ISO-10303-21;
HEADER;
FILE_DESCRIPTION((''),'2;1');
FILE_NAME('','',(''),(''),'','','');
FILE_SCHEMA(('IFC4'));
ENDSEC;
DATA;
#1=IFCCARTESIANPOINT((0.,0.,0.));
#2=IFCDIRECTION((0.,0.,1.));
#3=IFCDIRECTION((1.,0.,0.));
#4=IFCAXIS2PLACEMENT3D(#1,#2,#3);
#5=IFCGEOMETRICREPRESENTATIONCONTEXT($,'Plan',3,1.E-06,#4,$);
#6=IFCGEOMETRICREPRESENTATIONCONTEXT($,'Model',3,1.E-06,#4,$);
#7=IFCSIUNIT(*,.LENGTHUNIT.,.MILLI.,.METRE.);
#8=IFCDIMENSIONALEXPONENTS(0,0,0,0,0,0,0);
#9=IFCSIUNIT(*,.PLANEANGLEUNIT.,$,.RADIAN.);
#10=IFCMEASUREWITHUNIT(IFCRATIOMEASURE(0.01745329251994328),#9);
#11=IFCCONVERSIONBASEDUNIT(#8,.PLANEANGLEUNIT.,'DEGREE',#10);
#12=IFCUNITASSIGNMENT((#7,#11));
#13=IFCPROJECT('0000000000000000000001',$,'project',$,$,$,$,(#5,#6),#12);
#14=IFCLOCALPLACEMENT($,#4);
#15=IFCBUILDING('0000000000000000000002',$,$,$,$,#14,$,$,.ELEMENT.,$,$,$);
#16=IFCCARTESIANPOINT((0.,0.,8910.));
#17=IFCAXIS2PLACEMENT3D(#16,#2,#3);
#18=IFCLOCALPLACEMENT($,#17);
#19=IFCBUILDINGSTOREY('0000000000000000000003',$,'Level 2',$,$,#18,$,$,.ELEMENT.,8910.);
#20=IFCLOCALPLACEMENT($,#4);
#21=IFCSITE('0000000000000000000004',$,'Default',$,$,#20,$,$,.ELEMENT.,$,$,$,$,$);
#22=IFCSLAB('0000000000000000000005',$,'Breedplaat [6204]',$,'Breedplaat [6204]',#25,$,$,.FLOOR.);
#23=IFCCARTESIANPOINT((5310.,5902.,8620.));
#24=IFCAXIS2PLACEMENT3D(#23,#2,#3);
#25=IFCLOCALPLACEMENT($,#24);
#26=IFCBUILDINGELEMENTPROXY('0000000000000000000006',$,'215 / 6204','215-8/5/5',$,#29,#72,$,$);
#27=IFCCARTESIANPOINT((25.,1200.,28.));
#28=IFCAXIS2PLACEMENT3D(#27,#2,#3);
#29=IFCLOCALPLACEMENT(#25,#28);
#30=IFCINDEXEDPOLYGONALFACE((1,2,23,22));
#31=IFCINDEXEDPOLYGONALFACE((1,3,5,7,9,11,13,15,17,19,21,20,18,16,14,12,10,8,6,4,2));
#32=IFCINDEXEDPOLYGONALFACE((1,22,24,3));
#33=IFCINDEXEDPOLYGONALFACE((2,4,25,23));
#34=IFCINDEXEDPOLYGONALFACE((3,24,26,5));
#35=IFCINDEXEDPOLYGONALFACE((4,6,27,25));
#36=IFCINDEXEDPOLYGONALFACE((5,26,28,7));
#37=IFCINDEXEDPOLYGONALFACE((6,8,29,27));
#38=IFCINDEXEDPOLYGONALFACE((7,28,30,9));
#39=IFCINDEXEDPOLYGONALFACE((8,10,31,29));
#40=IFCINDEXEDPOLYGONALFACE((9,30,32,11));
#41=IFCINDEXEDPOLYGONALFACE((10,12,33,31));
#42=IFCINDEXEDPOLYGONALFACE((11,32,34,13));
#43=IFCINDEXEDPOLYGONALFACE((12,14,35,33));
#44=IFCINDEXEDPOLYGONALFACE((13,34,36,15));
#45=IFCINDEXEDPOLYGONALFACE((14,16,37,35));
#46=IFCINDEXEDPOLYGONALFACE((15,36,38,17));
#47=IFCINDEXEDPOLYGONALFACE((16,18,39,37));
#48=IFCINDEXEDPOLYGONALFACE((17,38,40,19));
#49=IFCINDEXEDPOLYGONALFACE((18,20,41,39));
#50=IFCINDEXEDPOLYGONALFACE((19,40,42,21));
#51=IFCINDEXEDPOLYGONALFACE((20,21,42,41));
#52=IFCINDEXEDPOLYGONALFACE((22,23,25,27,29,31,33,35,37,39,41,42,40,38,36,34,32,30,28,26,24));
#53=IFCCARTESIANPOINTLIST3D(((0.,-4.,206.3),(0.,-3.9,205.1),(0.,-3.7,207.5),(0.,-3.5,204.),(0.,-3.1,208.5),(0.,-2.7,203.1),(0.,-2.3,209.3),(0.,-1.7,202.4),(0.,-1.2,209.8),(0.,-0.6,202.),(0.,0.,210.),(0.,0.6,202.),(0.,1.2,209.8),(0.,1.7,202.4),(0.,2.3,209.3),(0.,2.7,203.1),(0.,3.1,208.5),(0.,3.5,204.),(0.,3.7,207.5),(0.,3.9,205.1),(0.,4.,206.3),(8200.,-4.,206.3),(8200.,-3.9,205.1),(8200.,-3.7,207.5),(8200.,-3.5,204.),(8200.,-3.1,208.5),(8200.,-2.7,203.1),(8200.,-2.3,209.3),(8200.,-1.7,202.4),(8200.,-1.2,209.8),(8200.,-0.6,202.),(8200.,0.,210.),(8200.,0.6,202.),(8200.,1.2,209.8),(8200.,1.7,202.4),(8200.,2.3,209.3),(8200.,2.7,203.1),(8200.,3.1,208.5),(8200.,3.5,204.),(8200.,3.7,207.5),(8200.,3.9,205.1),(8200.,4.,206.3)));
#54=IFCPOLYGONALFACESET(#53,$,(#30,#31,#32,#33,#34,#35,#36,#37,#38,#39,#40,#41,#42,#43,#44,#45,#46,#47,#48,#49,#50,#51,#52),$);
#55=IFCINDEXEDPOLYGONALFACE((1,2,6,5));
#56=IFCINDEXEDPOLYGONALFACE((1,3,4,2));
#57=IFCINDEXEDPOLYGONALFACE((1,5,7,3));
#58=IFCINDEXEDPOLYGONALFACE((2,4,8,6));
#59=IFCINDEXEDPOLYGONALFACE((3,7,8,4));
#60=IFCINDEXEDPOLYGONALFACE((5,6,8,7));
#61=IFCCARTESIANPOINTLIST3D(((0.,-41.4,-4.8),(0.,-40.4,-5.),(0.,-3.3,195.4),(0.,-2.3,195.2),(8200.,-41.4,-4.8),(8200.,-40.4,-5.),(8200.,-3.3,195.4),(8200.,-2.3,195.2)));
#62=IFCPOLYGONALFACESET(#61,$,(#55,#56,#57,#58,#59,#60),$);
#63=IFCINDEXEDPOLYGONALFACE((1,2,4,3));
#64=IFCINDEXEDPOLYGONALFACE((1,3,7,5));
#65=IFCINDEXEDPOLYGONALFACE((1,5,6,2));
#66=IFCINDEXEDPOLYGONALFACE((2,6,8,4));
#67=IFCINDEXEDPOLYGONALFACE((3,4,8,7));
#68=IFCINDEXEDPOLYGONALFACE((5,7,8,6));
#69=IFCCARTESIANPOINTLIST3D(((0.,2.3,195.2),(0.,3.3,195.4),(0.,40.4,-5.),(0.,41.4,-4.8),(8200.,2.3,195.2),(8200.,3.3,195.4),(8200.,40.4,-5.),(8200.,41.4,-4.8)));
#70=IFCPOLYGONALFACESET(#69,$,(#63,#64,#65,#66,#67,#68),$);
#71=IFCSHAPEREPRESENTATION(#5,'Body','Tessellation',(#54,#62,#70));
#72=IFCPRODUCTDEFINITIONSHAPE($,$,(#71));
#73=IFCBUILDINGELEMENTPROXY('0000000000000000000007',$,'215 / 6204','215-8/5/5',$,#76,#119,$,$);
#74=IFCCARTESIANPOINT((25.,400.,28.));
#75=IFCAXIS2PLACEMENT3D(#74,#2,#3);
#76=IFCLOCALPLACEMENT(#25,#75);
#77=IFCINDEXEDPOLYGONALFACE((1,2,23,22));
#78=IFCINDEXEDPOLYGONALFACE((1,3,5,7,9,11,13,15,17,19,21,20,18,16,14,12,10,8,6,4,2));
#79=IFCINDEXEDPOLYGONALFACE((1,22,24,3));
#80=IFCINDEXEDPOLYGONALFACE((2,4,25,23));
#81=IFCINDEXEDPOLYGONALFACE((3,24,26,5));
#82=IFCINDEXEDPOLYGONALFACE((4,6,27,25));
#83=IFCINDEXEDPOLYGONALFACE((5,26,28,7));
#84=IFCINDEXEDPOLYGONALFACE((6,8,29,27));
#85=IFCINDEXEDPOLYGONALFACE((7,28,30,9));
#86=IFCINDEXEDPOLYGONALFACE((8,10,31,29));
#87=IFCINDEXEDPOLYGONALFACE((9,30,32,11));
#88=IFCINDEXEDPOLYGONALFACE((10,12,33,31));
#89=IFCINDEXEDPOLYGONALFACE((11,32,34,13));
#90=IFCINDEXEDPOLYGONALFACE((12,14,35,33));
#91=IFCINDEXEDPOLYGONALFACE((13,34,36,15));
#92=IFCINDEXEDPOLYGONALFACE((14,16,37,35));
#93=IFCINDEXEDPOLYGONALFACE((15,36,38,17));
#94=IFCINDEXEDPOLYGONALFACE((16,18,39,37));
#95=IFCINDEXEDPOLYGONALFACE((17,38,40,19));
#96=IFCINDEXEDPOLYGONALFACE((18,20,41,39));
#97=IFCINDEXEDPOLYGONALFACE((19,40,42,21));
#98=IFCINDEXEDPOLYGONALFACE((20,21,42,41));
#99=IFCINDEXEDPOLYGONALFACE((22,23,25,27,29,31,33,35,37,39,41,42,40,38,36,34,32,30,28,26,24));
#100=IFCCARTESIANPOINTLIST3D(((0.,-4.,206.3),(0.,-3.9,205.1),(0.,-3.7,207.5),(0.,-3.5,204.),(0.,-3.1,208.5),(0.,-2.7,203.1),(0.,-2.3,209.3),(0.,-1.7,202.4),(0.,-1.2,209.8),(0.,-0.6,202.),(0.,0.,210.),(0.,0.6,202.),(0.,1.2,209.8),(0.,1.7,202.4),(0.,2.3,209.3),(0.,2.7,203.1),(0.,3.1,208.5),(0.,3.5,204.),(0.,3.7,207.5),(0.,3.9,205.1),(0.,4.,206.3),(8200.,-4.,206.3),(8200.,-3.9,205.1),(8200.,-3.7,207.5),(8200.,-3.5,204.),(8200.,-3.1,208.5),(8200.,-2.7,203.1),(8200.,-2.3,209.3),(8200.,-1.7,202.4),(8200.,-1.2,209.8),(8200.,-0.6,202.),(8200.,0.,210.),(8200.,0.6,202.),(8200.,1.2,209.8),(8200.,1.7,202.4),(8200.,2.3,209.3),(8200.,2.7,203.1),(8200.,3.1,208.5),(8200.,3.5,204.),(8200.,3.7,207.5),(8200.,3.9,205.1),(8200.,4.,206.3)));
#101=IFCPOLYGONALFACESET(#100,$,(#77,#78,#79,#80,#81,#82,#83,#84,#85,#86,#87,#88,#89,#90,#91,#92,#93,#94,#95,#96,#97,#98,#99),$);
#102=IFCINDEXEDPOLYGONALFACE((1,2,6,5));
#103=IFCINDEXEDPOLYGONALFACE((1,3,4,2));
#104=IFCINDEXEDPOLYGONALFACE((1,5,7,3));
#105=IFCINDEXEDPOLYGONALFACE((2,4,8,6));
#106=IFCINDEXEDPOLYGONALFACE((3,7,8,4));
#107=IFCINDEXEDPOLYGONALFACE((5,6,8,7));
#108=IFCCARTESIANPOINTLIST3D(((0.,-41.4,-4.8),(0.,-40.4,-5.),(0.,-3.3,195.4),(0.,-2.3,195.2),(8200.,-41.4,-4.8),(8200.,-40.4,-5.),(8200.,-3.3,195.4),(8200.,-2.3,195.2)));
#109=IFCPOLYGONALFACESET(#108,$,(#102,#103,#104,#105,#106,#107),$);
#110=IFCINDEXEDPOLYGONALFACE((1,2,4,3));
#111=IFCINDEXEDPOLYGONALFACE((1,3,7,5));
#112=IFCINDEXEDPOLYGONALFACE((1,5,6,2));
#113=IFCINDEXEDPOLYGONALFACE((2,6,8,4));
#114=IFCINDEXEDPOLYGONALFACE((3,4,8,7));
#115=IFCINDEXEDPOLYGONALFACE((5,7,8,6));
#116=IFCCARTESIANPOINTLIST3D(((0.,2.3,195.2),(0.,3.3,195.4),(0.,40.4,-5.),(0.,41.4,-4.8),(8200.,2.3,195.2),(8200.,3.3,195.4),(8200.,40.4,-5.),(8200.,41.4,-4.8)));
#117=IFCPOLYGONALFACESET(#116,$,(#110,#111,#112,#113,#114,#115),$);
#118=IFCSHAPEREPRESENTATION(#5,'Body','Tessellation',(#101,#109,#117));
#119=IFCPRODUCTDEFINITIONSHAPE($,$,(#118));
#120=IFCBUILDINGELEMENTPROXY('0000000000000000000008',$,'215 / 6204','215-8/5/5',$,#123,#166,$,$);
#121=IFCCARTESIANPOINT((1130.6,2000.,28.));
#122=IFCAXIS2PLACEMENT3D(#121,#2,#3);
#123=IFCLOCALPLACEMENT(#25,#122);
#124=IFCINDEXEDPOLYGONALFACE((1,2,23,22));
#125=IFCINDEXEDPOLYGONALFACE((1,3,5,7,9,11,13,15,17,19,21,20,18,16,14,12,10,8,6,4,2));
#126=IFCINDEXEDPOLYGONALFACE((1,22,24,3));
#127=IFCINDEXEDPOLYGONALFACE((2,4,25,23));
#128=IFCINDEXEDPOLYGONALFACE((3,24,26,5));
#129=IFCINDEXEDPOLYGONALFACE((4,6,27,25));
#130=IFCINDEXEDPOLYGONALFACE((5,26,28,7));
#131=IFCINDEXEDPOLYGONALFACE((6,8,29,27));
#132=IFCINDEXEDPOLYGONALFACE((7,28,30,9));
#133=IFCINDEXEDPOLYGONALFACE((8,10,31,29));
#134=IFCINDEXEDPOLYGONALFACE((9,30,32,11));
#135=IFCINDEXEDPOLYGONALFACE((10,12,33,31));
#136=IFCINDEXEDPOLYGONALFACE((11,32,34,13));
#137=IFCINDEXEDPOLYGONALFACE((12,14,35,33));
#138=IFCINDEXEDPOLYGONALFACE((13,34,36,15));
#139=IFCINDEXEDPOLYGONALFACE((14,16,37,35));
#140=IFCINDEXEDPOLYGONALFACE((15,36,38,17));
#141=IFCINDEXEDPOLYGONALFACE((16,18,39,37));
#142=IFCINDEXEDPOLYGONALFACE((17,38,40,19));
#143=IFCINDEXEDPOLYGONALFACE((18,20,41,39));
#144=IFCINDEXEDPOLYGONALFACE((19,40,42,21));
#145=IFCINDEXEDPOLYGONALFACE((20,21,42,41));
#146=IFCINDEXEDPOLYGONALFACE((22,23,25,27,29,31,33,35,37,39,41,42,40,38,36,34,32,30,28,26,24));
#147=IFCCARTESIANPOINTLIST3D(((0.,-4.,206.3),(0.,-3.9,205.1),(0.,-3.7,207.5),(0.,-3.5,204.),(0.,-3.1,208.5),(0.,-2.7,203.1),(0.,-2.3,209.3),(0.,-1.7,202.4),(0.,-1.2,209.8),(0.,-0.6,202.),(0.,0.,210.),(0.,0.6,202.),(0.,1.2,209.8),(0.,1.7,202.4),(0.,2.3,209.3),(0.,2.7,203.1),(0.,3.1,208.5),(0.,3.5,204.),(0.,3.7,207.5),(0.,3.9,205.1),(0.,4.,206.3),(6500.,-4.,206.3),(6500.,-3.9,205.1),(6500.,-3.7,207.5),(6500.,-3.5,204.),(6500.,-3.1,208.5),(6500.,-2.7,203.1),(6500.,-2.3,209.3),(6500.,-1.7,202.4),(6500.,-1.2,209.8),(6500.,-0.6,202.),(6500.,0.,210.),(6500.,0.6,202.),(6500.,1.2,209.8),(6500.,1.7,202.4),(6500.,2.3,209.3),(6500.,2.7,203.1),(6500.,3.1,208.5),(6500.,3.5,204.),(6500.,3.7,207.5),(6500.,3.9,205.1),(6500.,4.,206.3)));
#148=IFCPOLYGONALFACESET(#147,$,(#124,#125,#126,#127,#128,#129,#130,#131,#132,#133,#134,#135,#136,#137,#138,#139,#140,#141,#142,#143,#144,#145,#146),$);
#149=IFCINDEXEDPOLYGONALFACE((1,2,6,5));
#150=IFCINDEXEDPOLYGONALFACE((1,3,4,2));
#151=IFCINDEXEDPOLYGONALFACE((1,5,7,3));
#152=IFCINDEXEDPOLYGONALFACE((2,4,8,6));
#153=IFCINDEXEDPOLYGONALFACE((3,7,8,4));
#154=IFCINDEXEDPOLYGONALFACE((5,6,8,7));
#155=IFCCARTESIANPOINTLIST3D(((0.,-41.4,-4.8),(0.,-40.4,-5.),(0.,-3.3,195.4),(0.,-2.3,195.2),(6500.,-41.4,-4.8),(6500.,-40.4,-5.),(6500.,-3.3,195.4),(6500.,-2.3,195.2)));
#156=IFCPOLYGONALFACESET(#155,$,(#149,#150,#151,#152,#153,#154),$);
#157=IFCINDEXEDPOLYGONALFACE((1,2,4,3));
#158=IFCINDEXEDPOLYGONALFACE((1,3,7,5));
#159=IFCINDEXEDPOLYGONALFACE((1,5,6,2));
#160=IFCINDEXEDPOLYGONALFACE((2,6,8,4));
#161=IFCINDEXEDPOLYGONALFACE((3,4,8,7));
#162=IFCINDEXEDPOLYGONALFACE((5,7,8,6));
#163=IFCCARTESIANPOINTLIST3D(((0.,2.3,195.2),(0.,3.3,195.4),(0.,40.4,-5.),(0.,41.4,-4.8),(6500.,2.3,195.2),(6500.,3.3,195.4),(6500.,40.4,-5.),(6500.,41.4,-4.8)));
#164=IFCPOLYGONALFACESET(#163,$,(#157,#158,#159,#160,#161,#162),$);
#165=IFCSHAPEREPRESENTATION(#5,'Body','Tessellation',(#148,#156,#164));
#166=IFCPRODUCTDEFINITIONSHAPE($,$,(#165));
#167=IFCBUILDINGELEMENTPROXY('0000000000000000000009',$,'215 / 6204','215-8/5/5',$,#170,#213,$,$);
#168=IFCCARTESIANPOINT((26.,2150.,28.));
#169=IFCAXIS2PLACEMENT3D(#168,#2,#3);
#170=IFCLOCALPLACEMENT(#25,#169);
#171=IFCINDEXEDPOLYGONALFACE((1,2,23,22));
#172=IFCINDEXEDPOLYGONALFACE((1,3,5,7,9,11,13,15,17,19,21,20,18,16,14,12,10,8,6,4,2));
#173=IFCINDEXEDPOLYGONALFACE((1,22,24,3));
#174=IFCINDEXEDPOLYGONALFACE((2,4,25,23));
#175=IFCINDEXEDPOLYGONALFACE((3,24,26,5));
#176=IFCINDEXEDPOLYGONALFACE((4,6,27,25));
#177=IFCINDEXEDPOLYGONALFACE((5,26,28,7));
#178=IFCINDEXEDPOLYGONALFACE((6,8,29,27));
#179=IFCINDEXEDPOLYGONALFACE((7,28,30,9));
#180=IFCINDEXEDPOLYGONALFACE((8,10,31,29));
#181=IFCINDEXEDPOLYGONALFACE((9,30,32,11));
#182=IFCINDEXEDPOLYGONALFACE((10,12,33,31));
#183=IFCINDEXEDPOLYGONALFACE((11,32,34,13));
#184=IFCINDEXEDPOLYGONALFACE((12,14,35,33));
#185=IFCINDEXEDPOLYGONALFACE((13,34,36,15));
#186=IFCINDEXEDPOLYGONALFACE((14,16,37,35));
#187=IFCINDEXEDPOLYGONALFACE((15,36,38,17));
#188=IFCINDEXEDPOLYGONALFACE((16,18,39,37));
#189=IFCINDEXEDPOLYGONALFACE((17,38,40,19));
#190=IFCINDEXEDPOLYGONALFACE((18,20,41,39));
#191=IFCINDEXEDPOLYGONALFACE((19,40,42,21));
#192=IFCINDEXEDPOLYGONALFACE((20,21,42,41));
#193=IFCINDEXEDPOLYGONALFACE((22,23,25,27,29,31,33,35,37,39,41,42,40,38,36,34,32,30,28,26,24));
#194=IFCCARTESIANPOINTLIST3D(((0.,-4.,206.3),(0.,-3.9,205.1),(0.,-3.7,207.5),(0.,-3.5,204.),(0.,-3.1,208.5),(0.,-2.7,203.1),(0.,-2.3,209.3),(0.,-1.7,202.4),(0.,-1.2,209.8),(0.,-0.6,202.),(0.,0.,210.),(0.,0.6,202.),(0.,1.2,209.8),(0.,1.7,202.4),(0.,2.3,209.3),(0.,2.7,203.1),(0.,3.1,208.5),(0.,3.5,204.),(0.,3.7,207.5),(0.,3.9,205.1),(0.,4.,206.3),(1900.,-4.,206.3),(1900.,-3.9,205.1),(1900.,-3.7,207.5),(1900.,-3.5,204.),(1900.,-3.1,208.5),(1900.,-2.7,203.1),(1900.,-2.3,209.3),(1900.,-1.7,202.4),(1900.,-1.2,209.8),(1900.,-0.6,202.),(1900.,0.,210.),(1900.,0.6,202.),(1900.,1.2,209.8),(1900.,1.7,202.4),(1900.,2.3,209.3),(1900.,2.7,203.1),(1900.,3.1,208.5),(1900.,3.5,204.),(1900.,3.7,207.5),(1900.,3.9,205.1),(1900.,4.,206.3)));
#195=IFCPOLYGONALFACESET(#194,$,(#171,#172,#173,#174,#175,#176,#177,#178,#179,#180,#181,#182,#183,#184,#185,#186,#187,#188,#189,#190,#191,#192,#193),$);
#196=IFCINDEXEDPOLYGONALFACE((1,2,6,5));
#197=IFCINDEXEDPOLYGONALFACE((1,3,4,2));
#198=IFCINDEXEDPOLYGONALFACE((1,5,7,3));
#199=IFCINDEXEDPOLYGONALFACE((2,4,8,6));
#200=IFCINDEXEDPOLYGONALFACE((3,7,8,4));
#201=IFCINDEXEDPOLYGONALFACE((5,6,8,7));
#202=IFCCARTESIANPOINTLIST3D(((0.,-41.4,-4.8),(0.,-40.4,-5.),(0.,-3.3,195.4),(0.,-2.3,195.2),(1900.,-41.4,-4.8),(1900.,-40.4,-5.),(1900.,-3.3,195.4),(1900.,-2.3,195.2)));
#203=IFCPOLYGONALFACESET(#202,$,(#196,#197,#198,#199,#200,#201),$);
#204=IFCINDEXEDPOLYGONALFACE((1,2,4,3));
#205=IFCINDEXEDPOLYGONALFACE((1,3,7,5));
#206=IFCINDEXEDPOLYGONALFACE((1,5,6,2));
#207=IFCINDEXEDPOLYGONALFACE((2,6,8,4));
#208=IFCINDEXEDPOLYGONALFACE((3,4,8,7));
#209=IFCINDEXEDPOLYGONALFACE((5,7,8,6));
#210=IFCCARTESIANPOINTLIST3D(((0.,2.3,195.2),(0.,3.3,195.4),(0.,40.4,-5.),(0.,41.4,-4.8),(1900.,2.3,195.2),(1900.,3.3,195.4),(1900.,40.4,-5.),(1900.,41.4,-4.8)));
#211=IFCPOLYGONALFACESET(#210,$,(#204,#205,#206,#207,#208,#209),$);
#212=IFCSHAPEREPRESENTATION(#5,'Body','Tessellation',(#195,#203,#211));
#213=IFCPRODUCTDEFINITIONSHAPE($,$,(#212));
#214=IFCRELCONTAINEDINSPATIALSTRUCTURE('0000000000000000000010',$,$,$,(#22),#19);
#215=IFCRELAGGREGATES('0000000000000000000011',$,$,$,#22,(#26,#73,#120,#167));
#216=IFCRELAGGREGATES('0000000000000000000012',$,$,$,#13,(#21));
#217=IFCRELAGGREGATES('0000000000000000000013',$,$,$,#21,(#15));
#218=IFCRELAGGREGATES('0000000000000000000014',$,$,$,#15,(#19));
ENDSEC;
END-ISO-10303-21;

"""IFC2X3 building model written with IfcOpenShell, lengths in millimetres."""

from ifc_helpers import new_model, entity, si_unit, converted_unit, frame, origin_with_axes, origin_2d_with_axis, place, context, project, spatial, rectangle, circle, extrude, element, aggregate, save


model = new_model("IFC2X3")

# Units and contexts
plan_context = context("Plan", 3, precision=1e-06, world=origin_with_axes())
model_context = context("Model", 3, precision=1e-06, world=origin_with_axes())
ifc_project = project(units=[si_unit("LENGTHUNIT", "METRE", prefix="MILLI"), converted_unit("PLANEANGLEUNIT", "DEGREE", entity("IfcRatioMeasure", 0.01745329251994328), si_unit("PLANEANGLEUNIT", "RADIAN"), dimensions=[0, 0, 0, 0, 0, 0, 0])], contexts=[plan_context, model_context])

# Site, building, storey
site_placement = place(None, origin_with_axes())
site = spatial("IfcSite", under=ifc_project, at=site_placement, Name="Default", CompositionType="ELEMENT")
building_placement = place(None, origin_with_axes())
building = spatial("IfcBuilding", under=site, at=building_placement, CompositionType="ELEMENT")
storey_placement = place(None, frame((0.0, 0.0, 8910.0), z_axis=(0.0, 0.0, 1.0), x_axis=(1.0, 0.0, 0.0)))
storey = spatial("IfcBuildingStorey", under=building, at=storey_placement, Name="Level 2", CompositionType="ELEMENT", Elevation=8910.0)

# Slab, building element proxies
slab_1_placement = place(None, frame((5310.0, 5902.0, 8620.0), z_axis=(0.0, 0.0, 1.0), x_axis=(1.0, 0.0, 0.0)))
slab_1 = element("IfcSlab", 1, at=slab_1_placement, inside=storey, Name="Breedplaat [6204]", ObjectType="Breedplaat [6204]", PredefinedType="FLOOR")
proxy_1_placement = place(slab_1_placement, frame((25.0, 1200.0, 28.0), z_axis=(0.0, 0.0, 1.0), x_axis=(1.0, 0.0, 0.0)))
proxy_1 = element("IfcBuildingElementProxy", 2, at=proxy_1_placement, Name="215 / 6204", Description="215-8/5/5", context=plan_context, shape_type="SweptSolid", body=[
    extrude(circle(Radius=4.0, at=origin_2d_with_axis()), frame((0.0, 0.0, 206.0), z_axis=(1.0, 0.0, 0.0), x_axis=(0.0, 0.0, 1.0)), (0.0, 0.0, 1.0), 8200.0),
    extrude(rectangle(XDim=203.8, YDim=1.0, at=origin_2d_with_axis()), frame((0.0, -21.9, 95.2), z_axis=(1.0, 0.0, 0.0), x_axis=(0.0, 0.187112, 0.982339)), (0.0, 0.0, 1.0), 8200.0),
    extrude(rectangle(XDim=203.8, YDim=1.0, at=origin_2d_with_axis()), frame((0.0, 21.9, 95.2), z_axis=(1.0, 0.0, 0.0), x_axis=(0.0, -0.187112, 0.982339)), (0.0, 0.0, 1.0), 8200.0),
])
proxy_2_placement = place(slab_1_placement, frame((25.0, 400.0, 28.0), z_axis=(0.0, 0.0, 1.0), x_axis=(1.0, 0.0, 0.0)))
proxy_2 = element("IfcBuildingElementProxy", 3, at=proxy_2_placement, Name="215 / 6204", Description="215-8/5/5", context=plan_context, shape_type="SweptSolid", body=[
    extrude(circle(Radius=4.0, at=origin_2d_with_axis()), frame((0.0, 0.0, 206.0), z_axis=(1.0, 0.0, 0.0), x_axis=(0.0, 0.0, 1.0)), (0.0, 0.0, 1.0), 8200.0),
    extrude(rectangle(XDim=203.8, YDim=1.0, at=origin_2d_with_axis()), frame((0.0, -21.9, 95.2), z_axis=(1.0, 0.0, 0.0), x_axis=(0.0, 0.187112, 0.982339)), (0.0, 0.0, 1.0), 8200.0),
    extrude(rectangle(XDim=203.8, YDim=1.0, at=origin_2d_with_axis()), frame((0.0, 21.9, 95.2), z_axis=(1.0, 0.0, 0.0), x_axis=(0.0, -0.187112, 0.982339)), (0.0, 0.0, 1.0), 8200.0),
])
proxy_3_placement = place(slab_1_placement, frame((1130.6, 2000.0, 28.0), z_axis=(0.0, 0.0, 1.0), x_axis=(1.0, 0.0, 0.0)))
proxy_3 = element("IfcBuildingElementProxy", 4, at=proxy_3_placement, Name="215 / 6204", Description="215-8/5/5", context=plan_context, shape_type="SweptSolid", body=[
    extrude(circle(Radius=4.0, at=origin_2d_with_axis()), frame((0.0, 0.0, 206.0), z_axis=(1.0, 0.0, 0.0), x_axis=(0.0, 0.0, 1.0)), (0.0, 0.0, 1.0), 6500.0),
    extrude(rectangle(XDim=203.8, YDim=1.0, at=origin_2d_with_axis()), frame((0.0, -21.9, 95.2), z_axis=(1.0, 0.0, 0.0), x_axis=(0.0, 0.187112, 0.982339)), (0.0, 0.0, 1.0), 6500.0),
    extrude(rectangle(XDim=203.8, YDim=1.0, at=origin_2d_with_axis()), frame((0.0, 21.9, 95.2), z_axis=(1.0, 0.0, 0.0), x_axis=(0.0, -0.187112, 0.982339)), (0.0, 0.0, 1.0), 6500.0),
])
proxy_4_placement = place(slab_1_placement, frame((26.0, 2150.0, 28.0), z_axis=(0.0, 0.0, 1.0), x_axis=(1.0, 0.0, 0.0)))
proxy_4 = element("IfcBuildingElementProxy", 5, at=proxy_4_placement, Name="215 / 6204", Description="215-8/5/5", context=plan_context, shape_type="SweptSolid", body=[
    extrude(circle(Radius=4.0, at=origin_2d_with_axis()), frame((0.0, 0.0, 206.0), z_axis=(1.0, 0.0, 0.0), x_axis=(0.0, 0.0, 1.0)), (0.0, 0.0, 1.0), 1900.0),
    extrude(rectangle(XDim=203.8, YDim=1.0, at=origin_2d_with_axis()), frame((0.0, -21.9, 95.2), z_axis=(1.0, 0.0, 0.0), x_axis=(0.0, 0.187112, 0.982339)), (0.0, 0.0, 1.0), 1900.0),
    extrude(rectangle(XDim=203.8, YDim=1.0, at=origin_2d_with_axis()), frame((0.0, 21.9, 95.2), z_axis=(1.0, 0.0, 0.0), x_axis=(0.0, -0.187112, 0.982339)), (0.0, 0.0, 1.0), 1900.0),
])
aggregate(slab_1, [proxy_1, proxy_2, proxy_3, proxy_4])

save(model, "model.ifc")
